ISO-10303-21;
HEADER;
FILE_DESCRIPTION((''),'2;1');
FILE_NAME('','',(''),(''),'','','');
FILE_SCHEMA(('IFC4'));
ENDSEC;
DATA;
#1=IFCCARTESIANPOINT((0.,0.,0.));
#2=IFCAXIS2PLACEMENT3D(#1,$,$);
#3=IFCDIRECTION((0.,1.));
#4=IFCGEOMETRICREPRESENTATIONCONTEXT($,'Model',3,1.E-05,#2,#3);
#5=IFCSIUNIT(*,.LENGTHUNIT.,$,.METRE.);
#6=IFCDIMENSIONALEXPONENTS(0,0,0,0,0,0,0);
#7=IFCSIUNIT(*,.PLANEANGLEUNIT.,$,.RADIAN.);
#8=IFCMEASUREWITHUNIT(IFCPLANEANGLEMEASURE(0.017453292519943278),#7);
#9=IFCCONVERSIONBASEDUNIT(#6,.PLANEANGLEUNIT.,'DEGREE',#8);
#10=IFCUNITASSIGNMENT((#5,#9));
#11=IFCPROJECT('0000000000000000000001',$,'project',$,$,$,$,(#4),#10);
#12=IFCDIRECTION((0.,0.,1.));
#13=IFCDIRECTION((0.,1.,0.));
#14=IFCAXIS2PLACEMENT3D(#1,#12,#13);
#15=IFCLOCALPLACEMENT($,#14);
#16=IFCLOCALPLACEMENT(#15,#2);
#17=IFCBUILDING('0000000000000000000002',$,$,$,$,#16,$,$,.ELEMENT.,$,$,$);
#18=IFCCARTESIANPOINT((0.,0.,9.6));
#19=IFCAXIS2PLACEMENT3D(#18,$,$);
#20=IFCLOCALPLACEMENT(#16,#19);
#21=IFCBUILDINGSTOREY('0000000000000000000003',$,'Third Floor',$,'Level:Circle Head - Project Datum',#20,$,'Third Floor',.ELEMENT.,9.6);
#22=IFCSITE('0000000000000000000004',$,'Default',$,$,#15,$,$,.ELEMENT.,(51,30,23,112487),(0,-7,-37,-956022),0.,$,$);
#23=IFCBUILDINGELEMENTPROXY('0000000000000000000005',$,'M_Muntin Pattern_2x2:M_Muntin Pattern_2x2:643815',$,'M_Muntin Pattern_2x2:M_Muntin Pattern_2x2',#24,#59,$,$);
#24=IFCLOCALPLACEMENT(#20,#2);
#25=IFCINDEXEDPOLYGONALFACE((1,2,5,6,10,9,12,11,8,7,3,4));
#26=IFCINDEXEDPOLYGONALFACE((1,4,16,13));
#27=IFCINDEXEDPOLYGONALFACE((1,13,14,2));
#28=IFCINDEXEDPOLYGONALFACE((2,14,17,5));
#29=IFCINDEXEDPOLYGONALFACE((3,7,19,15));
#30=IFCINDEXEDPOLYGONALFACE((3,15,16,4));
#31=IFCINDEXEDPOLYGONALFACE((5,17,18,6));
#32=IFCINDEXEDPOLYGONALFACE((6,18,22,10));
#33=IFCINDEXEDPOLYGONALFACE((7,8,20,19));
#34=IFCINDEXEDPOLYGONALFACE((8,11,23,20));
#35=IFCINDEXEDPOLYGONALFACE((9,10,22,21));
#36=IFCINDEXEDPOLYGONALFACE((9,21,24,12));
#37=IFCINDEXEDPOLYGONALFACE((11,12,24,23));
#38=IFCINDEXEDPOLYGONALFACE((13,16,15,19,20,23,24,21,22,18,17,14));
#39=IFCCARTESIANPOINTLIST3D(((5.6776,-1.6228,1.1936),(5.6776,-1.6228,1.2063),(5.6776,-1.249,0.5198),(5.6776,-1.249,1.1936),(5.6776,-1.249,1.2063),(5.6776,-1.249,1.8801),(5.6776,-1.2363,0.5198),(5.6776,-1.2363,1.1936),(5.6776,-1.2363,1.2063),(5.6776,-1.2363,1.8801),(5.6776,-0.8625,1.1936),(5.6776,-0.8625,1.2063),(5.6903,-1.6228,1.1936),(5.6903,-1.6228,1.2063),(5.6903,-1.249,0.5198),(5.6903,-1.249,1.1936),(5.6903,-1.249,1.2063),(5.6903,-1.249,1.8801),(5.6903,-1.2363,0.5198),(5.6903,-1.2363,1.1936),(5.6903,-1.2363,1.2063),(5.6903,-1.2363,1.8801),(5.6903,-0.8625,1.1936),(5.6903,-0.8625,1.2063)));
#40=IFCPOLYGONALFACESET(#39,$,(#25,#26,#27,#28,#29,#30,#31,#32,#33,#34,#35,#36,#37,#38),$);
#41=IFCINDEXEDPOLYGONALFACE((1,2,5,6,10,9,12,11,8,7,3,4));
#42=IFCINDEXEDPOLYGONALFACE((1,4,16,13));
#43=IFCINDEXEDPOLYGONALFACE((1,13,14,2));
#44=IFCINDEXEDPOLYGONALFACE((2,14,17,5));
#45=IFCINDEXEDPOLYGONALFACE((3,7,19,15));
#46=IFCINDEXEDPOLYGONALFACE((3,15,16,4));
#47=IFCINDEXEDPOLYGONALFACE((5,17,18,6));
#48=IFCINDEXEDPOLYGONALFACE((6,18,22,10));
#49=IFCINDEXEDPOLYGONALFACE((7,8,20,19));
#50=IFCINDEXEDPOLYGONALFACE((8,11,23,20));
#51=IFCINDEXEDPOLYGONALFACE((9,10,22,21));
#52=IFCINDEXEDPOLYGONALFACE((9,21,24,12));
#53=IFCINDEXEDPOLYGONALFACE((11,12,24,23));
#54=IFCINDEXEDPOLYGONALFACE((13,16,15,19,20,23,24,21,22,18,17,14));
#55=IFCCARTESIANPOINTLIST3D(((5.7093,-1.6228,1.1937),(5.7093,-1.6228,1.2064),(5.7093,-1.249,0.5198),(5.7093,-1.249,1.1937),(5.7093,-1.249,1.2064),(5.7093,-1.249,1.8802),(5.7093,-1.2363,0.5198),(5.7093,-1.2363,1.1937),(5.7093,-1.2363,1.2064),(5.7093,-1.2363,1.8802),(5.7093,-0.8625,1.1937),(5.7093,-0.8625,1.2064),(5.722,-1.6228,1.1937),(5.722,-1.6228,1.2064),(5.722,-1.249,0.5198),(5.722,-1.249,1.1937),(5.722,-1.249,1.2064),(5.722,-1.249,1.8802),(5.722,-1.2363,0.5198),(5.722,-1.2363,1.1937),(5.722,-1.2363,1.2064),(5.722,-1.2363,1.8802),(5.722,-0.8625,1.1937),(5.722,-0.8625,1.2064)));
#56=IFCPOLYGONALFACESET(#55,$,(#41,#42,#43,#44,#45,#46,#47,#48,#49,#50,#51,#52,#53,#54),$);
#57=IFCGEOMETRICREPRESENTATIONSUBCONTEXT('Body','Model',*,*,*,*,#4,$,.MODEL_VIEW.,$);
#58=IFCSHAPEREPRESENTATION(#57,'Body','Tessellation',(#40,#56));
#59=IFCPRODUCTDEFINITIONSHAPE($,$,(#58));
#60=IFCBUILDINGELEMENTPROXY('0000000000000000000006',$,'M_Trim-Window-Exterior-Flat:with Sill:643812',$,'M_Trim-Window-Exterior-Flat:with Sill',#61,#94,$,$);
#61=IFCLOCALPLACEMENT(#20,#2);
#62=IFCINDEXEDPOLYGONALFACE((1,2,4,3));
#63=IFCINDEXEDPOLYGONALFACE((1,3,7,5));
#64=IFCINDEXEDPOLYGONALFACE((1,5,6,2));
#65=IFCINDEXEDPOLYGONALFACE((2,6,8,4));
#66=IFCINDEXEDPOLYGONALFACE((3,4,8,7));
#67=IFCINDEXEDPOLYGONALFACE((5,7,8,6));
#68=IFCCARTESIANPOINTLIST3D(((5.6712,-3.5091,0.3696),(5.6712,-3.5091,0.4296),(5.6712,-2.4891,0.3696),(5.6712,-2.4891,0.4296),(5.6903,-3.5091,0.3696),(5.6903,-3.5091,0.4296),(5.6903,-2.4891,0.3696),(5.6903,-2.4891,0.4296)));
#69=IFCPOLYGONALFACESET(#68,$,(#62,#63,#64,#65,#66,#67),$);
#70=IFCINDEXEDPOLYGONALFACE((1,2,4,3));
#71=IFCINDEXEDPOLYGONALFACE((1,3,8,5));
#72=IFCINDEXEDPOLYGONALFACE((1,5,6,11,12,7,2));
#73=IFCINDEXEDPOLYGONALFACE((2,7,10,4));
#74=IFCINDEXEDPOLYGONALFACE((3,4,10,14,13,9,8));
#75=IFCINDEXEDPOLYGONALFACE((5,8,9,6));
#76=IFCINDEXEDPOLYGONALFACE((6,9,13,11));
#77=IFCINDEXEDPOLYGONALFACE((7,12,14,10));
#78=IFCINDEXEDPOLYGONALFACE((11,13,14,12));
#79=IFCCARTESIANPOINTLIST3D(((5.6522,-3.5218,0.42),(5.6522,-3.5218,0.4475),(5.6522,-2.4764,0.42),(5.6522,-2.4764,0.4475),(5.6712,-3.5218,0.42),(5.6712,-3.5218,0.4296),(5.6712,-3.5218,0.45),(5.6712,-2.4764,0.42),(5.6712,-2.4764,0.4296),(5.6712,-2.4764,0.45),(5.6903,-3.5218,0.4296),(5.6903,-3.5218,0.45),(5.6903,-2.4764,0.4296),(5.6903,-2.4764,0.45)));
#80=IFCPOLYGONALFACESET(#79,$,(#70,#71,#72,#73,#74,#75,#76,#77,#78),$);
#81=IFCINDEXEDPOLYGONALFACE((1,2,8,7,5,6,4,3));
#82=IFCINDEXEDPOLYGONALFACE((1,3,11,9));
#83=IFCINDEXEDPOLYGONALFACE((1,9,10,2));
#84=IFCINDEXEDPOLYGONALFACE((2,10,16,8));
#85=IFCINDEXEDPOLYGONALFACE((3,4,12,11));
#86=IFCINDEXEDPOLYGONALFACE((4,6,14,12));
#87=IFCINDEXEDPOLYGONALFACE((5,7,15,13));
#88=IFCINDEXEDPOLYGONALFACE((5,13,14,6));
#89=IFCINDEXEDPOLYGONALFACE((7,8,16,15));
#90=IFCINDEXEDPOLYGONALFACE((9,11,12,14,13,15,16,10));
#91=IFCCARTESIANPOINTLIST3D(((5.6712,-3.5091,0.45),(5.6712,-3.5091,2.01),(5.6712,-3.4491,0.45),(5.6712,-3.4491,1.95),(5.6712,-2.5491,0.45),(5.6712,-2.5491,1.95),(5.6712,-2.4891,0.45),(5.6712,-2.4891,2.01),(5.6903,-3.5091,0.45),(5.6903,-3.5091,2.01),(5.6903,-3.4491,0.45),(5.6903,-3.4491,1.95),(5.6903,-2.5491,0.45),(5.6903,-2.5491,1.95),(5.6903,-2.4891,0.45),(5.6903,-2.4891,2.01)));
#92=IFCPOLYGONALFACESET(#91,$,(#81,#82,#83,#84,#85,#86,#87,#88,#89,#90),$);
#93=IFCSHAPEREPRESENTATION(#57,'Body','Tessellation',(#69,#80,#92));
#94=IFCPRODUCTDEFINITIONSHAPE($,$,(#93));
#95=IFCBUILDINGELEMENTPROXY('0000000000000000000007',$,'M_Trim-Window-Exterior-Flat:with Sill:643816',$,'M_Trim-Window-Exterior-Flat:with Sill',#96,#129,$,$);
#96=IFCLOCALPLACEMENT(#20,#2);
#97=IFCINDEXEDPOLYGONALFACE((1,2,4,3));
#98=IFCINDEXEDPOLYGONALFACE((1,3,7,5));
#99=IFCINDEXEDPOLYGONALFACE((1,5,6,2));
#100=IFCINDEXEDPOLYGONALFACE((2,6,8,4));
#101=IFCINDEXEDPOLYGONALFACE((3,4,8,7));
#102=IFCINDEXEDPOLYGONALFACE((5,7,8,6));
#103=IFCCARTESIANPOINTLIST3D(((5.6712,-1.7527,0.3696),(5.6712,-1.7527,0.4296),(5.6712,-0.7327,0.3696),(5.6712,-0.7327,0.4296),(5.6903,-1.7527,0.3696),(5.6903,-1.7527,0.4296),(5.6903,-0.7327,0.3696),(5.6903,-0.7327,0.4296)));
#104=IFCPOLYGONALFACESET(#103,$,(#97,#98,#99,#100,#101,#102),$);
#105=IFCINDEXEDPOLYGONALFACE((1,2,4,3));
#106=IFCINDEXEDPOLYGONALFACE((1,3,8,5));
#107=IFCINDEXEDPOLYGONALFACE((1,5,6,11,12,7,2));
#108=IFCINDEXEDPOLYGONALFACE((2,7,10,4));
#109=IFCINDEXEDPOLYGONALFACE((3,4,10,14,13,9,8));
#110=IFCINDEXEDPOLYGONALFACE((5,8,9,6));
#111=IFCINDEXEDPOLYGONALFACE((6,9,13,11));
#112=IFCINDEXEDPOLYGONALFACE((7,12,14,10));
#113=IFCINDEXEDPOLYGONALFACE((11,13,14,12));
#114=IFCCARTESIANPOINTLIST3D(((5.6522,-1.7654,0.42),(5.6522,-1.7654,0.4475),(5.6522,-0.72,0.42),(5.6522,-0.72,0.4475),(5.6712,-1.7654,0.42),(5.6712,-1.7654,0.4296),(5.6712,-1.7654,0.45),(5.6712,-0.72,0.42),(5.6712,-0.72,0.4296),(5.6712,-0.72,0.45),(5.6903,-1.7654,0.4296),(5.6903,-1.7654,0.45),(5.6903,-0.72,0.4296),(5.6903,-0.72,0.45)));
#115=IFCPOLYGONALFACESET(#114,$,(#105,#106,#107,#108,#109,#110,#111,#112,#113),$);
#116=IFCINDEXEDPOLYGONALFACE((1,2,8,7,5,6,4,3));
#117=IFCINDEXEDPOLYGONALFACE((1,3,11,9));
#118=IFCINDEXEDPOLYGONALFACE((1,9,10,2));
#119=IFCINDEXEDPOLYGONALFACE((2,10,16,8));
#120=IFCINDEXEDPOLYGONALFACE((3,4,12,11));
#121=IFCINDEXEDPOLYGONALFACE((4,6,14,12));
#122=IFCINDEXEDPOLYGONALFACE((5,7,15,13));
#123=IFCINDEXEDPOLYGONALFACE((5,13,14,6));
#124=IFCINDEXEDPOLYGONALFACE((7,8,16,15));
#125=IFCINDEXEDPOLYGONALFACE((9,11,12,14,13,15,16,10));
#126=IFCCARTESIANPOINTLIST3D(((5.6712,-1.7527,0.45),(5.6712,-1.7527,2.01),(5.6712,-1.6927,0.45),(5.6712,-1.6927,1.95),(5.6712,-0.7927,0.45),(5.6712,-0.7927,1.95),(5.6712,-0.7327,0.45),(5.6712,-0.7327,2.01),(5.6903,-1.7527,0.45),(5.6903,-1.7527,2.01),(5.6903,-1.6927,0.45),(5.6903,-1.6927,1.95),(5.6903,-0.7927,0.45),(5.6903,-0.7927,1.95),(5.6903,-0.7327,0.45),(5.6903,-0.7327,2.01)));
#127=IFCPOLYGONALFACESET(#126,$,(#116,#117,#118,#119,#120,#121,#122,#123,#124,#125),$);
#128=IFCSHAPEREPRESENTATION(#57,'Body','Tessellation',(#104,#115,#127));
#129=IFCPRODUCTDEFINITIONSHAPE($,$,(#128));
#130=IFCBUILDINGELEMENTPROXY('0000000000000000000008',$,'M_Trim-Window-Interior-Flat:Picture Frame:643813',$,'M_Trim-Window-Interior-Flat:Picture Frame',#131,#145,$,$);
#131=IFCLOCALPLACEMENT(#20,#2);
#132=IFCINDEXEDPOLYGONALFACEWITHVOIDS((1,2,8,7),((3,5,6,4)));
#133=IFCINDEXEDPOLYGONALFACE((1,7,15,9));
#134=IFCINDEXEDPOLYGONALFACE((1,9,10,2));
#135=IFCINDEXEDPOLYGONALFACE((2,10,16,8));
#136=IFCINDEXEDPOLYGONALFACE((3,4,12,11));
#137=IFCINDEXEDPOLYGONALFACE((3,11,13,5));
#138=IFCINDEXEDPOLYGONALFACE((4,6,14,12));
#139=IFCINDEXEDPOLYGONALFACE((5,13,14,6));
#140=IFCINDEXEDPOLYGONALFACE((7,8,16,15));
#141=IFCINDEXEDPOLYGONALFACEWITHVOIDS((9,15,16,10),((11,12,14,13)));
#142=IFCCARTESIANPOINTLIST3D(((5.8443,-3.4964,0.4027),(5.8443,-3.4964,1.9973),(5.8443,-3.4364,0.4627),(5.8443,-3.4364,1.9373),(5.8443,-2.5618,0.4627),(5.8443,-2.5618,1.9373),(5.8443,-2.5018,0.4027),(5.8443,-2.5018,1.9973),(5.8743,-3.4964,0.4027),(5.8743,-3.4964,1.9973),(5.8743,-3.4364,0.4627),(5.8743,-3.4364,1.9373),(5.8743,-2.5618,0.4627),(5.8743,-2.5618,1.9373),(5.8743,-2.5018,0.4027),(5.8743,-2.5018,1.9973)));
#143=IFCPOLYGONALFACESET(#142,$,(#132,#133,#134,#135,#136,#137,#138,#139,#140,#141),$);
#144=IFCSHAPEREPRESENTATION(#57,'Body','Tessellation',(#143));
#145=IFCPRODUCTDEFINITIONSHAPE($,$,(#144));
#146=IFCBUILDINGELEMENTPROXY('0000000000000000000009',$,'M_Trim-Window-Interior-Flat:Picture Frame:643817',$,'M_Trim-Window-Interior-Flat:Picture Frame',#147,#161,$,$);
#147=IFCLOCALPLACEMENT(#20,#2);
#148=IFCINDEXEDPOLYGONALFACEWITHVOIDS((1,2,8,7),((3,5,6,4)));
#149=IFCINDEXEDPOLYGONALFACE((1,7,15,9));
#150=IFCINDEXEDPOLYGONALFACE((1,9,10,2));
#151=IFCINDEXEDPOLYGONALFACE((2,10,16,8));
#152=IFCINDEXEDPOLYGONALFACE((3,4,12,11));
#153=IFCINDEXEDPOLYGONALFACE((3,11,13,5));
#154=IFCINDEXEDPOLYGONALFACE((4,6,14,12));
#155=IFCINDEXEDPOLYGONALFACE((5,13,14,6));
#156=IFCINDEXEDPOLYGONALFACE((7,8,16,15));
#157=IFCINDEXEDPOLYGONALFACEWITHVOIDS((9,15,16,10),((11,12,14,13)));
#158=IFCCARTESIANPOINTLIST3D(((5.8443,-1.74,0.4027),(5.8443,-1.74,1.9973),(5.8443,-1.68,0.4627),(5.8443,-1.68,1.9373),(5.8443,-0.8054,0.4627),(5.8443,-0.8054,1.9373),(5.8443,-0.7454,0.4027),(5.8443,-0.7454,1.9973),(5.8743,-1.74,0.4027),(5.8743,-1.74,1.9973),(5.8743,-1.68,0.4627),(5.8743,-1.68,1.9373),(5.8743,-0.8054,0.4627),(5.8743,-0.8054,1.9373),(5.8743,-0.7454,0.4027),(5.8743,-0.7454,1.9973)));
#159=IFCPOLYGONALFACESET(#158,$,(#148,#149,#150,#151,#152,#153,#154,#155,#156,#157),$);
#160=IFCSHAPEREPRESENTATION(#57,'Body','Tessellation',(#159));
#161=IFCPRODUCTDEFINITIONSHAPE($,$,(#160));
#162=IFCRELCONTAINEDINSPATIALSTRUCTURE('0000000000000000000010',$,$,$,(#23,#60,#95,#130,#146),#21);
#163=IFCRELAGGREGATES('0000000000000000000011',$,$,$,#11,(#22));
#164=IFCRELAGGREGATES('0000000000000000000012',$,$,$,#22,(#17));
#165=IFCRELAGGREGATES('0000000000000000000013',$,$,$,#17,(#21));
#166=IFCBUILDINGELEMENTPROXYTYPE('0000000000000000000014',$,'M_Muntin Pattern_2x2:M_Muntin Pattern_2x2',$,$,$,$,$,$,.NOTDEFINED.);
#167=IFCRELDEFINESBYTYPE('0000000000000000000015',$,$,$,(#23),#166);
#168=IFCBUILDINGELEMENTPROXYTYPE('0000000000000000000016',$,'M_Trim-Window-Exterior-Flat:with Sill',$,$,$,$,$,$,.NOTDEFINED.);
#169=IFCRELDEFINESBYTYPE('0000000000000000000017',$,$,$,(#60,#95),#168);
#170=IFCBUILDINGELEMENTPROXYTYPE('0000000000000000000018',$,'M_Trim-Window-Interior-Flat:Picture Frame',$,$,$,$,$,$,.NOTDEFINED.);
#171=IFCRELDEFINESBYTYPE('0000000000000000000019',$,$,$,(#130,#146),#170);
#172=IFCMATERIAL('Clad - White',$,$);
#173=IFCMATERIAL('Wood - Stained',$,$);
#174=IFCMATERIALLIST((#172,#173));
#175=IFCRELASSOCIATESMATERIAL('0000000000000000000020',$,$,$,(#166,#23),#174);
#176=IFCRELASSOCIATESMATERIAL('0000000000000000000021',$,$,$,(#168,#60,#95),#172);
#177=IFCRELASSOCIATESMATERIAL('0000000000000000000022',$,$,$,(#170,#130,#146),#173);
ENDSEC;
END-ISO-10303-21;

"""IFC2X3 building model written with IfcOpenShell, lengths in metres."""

from ifc_helpers import new_model, entity, si_unit, converted_unit, direction, frame, frame_2d, origin, place, context, subcontext, project, spatial, polyline, rectangle, outline, extrude, source, transform, mapped, material, material_list, type_object, type_shapes, element, save


model = new_model("IFC2X3")

# Units and contexts
model_context = context("Model", 3, precision=1e-05, world=origin(), true_north=direction((0.0, 1.0)))
body_context = subcontext(model_context, "Body", "Model", "MODEL_VIEW")
ifc_project = project(units=[si_unit("LENGTHUNIT", "METRE"), converted_unit("PLANEANGLEUNIT", "DEGREE", entity("IfcPlaneAngleMeasure", 0.017453292519943278), si_unit("PLANEANGLEUNIT", "RADIAN"), dimensions=[0, 0, 0, 0, 0, 0, 0])], contexts=[model_context])

# Site, building, storey
site_placement = place(None, frame((0.0, 0.0, 0.0), z_axis=(0.0, 0.0, 1.0), x_axis=(0.0, 1.0, 0.0)))
site = spatial("IfcSite", under=ifc_project, at=site_placement, Name="Default", CompositionType="ELEMENT", RefLatitude=(51, 30, 23, 112487), RefLongitude=(0, -7, -37, -956022), RefElevation=0.0)
building_placement = place(site_placement, origin())
building = spatial("IfcBuilding", under=site, at=building_placement, CompositionType="ELEMENT")
storey_placement = place(building_placement, frame((0.0, 0.0, 9.6)))
storey = spatial("IfcBuildingStorey", under=building, at=storey_placement, Name="Third Floor", ObjectType="Level:Circle Head - Project Datum", LongName="Third Floor", CompositionType="ELEMENT", Elevation=9.6)

# Building element proxies
ifc_material_1 = material(Name="Clad - White")
ifc_material_2 = material(Name="Wood - Stained")
ifc_material_list_1 = material_list([ifc_material_1, ifc_material_2])
building_element_proxy_type_1 = type_object("IfcBuildingElementProxyType", Name="M_Muntin Pattern_2x2:M_Muntin Pattern_2x2", PredefinedType="NOTDEFINED", material=ifc_material_list_1)
shared_shape_1 = source(origin(), body_context, "Body", "SweptSolid", [
    extrude(outline(polyline([(0.0064, -0.0064), (0.6801, -0.0064), (0.6801, 0.0063), (0.0064, 0.0063), (0.0064, 0.3802), (-0.0063, 0.3802), (-0.0063, 0.0063), (-0.6802, 0.0063), (-0.6802, -0.0064), (-0.0063, -0.0064), (-0.0063, -0.3801), (0.0064, -0.3801), (0.0064, -0.0064)])), frame((0.0, 0.0095, 0.6801), z_axis=(0.0, 1.0, 0.0), x_axis=(0.0, 0.0, 1.0)), (0.0, 0.0, 1.0), 0.0127),
    extrude(outline(polyline([(0.0064, -0.0064), (0.6802, -0.0064), (0.6802, 0.0063), (0.0064, 0.0063), (0.0064, 0.3802), (-0.0063, 0.3802), (-0.0063, 0.0063), (-0.6802, 0.0063), (-0.6802, -0.0064), (-0.0063, -0.0064), (-0.0063, -0.3801), (0.0064, -0.3801), (0.0064, -0.0064)])), frame((0.0, -0.0222, 0.6802), z_axis=(0.0, 1.0, 0.0), x_axis=(0.0, 0.0, 1.0)), (0.0, 0.0, 1.0), 0.0127),
])
type_shapes(building_element_proxy_type_1, [shared_shape_1])
for number, where, z_axis, x_axis, name in (
    (1, (5.6998, -1.2427, 0.5198), (0.0, 0.0, 1.0), (0.0, 1.0, 0.0), "M_Muntin Pattern_2x2:M_Muntin Pattern_2x2:643815"),
):
    element("IfcBuildingElementProxy", number, at=place(storey_placement, frame(where, z_axis=z_axis, x_axis=x_axis)), inside=storey, type_object=building_element_proxy_type_1, material=ifc_material_list_1, Name=name, ObjectType="M_Muntin Pattern_2x2:M_Muntin Pattern_2x2", context=body_context, shape_type="MappedRepresentation", body=[
        mapped(shared_shape_1, transform((0.0, 0.0, 0.0), scale=1.0)),
    ])
building_element_proxy_type_2 = type_object("IfcBuildingElementProxyType", Name="M_Trim-Window-Exterior-Flat:with Sill", PredefinedType="NOTDEFINED", material=ifc_material_1)
shared_shape_2 = source(origin(), body_context, "Body", "SweptSolid", [
    extrude(rectangle(XDim=1.02, YDim=0.06, at=frame_2d((0.0, 0.0), x_axis=(1.0, 0.0))), frame((0.0, -1.5504, 0.0), z_axis=(0.0, 0.0, 1.0), x_axis=(-1.0, 0.0, 0.0)), (0.0, 0.0, 1.0), 0.019),
    extrude(outline(polyline([(-0.019, -0.0152), (0.0, -0.0152), (0.0, -0.0057), (0.019, -0.0057), (0.019, 0.0148), (0.0, 0.0148), (-0.019, 0.0123), (-0.019, -0.0152)])), frame((-0.5227, -1.5148, 0.019), z_axis=(1.0, 0.0, 0.0), x_axis=(0.0, 0.0, -1.0)), (0.0, 0.0, 1.0), 1.0454),
    extrude(outline(polyline([(-0.795, -0.51), (0.765, -0.51), (0.765, -0.45), (-0.735, -0.45), (-0.735, 0.45), (0.765, 0.45), (0.765, 0.51), (-0.795, 0.51), (-0.795, -0.51)])), frame((0.0, -0.735, 0.0), z_axis=(0.0, 0.0, 1.0), x_axis=(0.0, -1.0, 0.0)), (0.0, 0.0, 1.0), 0.019),
])
type_shapes(building_element_proxy_type_2, [shared_shape_2])
for number, where, z_axis, x_axis, name in (
    (2, (5.6903, -2.9991, 1.95), (-1.0, 0.0, 0.0), (0.0, -1.0, 0.0), "M_Trim-Window-Exterior-Flat:with Sill:643812"),
    (3, (5.6903, -1.2427, 1.95), (-1.0, 0.0, 0.0), (0.0, -1.0, 0.0), "M_Trim-Window-Exterior-Flat:with Sill:643816"),
):
    element("IfcBuildingElementProxy", number, at=place(storey_placement, frame(where, z_axis=z_axis, x_axis=x_axis)), inside=storey, type_object=building_element_proxy_type_2, material=ifc_material_1, Name=name, ObjectType="M_Trim-Window-Exterior-Flat:with Sill", context=body_context, shape_type="MappedRepresentation", body=[
        mapped(shared_shape_2, transform((0.0, 0.0, 0.0), scale=1.0)),
    ])
building_element_proxy_type_3 = type_object("IfcBuildingElementProxyType", Name="M_Trim-Window-Interior-Flat:Picture Frame", PredefinedType="NOTDEFINED", material=ifc_material_2)
shared_shape_3 = source(origin(), body_context, "Body", "SweptSolid", [
    extrude(outline(polyline([(-0.4973, -0.7973), (0.4973, -0.7973), (0.4973, 0.7973), (-0.4973, 0.7973), (-0.4973, -0.7973)]), holes=[polyline([(-0.4373, -0.7373), (-0.4373, 0.7373), (0.4373, 0.7373), (0.4373, -0.7373), (-0.4373, -0.7373)])]), frame((0.0, -0.75, 0.0), z_axis=(0.0, 0.0, 1.0), x_axis=(-1.0, 0.0, 0.0)), (0.0, 0.0, 1.0), 0.03),
])
type_shapes(building_element_proxy_type_3, [shared_shape_3])
for number, where, z_axis, x_axis, name in (
    (4, (5.8443, -2.9991, 1.95), (1.0, 0.0, 0.0), (0.0, 1.0, 0.0), "M_Trim-Window-Interior-Flat:Picture Frame:643813"),
    (5, (5.8443, -1.2427, 1.95), (1.0, 0.0, 0.0), (0.0, 1.0, 0.0), "M_Trim-Window-Interior-Flat:Picture Frame:643817"),
):
    element("IfcBuildingElementProxy", number, at=place(storey_placement, frame(where, z_axis=z_axis, x_axis=x_axis)), inside=storey, type_object=building_element_proxy_type_3, material=ifc_material_2, Name=name, ObjectType="M_Trim-Window-Interior-Flat:Picture Frame", context=body_context, shape_type="MappedRepresentation", body=[
        mapped(shared_shape_3, transform((0.0, 0.0, 0.0), scale=1.0)),
    ])

save(model, "model.ifc")
